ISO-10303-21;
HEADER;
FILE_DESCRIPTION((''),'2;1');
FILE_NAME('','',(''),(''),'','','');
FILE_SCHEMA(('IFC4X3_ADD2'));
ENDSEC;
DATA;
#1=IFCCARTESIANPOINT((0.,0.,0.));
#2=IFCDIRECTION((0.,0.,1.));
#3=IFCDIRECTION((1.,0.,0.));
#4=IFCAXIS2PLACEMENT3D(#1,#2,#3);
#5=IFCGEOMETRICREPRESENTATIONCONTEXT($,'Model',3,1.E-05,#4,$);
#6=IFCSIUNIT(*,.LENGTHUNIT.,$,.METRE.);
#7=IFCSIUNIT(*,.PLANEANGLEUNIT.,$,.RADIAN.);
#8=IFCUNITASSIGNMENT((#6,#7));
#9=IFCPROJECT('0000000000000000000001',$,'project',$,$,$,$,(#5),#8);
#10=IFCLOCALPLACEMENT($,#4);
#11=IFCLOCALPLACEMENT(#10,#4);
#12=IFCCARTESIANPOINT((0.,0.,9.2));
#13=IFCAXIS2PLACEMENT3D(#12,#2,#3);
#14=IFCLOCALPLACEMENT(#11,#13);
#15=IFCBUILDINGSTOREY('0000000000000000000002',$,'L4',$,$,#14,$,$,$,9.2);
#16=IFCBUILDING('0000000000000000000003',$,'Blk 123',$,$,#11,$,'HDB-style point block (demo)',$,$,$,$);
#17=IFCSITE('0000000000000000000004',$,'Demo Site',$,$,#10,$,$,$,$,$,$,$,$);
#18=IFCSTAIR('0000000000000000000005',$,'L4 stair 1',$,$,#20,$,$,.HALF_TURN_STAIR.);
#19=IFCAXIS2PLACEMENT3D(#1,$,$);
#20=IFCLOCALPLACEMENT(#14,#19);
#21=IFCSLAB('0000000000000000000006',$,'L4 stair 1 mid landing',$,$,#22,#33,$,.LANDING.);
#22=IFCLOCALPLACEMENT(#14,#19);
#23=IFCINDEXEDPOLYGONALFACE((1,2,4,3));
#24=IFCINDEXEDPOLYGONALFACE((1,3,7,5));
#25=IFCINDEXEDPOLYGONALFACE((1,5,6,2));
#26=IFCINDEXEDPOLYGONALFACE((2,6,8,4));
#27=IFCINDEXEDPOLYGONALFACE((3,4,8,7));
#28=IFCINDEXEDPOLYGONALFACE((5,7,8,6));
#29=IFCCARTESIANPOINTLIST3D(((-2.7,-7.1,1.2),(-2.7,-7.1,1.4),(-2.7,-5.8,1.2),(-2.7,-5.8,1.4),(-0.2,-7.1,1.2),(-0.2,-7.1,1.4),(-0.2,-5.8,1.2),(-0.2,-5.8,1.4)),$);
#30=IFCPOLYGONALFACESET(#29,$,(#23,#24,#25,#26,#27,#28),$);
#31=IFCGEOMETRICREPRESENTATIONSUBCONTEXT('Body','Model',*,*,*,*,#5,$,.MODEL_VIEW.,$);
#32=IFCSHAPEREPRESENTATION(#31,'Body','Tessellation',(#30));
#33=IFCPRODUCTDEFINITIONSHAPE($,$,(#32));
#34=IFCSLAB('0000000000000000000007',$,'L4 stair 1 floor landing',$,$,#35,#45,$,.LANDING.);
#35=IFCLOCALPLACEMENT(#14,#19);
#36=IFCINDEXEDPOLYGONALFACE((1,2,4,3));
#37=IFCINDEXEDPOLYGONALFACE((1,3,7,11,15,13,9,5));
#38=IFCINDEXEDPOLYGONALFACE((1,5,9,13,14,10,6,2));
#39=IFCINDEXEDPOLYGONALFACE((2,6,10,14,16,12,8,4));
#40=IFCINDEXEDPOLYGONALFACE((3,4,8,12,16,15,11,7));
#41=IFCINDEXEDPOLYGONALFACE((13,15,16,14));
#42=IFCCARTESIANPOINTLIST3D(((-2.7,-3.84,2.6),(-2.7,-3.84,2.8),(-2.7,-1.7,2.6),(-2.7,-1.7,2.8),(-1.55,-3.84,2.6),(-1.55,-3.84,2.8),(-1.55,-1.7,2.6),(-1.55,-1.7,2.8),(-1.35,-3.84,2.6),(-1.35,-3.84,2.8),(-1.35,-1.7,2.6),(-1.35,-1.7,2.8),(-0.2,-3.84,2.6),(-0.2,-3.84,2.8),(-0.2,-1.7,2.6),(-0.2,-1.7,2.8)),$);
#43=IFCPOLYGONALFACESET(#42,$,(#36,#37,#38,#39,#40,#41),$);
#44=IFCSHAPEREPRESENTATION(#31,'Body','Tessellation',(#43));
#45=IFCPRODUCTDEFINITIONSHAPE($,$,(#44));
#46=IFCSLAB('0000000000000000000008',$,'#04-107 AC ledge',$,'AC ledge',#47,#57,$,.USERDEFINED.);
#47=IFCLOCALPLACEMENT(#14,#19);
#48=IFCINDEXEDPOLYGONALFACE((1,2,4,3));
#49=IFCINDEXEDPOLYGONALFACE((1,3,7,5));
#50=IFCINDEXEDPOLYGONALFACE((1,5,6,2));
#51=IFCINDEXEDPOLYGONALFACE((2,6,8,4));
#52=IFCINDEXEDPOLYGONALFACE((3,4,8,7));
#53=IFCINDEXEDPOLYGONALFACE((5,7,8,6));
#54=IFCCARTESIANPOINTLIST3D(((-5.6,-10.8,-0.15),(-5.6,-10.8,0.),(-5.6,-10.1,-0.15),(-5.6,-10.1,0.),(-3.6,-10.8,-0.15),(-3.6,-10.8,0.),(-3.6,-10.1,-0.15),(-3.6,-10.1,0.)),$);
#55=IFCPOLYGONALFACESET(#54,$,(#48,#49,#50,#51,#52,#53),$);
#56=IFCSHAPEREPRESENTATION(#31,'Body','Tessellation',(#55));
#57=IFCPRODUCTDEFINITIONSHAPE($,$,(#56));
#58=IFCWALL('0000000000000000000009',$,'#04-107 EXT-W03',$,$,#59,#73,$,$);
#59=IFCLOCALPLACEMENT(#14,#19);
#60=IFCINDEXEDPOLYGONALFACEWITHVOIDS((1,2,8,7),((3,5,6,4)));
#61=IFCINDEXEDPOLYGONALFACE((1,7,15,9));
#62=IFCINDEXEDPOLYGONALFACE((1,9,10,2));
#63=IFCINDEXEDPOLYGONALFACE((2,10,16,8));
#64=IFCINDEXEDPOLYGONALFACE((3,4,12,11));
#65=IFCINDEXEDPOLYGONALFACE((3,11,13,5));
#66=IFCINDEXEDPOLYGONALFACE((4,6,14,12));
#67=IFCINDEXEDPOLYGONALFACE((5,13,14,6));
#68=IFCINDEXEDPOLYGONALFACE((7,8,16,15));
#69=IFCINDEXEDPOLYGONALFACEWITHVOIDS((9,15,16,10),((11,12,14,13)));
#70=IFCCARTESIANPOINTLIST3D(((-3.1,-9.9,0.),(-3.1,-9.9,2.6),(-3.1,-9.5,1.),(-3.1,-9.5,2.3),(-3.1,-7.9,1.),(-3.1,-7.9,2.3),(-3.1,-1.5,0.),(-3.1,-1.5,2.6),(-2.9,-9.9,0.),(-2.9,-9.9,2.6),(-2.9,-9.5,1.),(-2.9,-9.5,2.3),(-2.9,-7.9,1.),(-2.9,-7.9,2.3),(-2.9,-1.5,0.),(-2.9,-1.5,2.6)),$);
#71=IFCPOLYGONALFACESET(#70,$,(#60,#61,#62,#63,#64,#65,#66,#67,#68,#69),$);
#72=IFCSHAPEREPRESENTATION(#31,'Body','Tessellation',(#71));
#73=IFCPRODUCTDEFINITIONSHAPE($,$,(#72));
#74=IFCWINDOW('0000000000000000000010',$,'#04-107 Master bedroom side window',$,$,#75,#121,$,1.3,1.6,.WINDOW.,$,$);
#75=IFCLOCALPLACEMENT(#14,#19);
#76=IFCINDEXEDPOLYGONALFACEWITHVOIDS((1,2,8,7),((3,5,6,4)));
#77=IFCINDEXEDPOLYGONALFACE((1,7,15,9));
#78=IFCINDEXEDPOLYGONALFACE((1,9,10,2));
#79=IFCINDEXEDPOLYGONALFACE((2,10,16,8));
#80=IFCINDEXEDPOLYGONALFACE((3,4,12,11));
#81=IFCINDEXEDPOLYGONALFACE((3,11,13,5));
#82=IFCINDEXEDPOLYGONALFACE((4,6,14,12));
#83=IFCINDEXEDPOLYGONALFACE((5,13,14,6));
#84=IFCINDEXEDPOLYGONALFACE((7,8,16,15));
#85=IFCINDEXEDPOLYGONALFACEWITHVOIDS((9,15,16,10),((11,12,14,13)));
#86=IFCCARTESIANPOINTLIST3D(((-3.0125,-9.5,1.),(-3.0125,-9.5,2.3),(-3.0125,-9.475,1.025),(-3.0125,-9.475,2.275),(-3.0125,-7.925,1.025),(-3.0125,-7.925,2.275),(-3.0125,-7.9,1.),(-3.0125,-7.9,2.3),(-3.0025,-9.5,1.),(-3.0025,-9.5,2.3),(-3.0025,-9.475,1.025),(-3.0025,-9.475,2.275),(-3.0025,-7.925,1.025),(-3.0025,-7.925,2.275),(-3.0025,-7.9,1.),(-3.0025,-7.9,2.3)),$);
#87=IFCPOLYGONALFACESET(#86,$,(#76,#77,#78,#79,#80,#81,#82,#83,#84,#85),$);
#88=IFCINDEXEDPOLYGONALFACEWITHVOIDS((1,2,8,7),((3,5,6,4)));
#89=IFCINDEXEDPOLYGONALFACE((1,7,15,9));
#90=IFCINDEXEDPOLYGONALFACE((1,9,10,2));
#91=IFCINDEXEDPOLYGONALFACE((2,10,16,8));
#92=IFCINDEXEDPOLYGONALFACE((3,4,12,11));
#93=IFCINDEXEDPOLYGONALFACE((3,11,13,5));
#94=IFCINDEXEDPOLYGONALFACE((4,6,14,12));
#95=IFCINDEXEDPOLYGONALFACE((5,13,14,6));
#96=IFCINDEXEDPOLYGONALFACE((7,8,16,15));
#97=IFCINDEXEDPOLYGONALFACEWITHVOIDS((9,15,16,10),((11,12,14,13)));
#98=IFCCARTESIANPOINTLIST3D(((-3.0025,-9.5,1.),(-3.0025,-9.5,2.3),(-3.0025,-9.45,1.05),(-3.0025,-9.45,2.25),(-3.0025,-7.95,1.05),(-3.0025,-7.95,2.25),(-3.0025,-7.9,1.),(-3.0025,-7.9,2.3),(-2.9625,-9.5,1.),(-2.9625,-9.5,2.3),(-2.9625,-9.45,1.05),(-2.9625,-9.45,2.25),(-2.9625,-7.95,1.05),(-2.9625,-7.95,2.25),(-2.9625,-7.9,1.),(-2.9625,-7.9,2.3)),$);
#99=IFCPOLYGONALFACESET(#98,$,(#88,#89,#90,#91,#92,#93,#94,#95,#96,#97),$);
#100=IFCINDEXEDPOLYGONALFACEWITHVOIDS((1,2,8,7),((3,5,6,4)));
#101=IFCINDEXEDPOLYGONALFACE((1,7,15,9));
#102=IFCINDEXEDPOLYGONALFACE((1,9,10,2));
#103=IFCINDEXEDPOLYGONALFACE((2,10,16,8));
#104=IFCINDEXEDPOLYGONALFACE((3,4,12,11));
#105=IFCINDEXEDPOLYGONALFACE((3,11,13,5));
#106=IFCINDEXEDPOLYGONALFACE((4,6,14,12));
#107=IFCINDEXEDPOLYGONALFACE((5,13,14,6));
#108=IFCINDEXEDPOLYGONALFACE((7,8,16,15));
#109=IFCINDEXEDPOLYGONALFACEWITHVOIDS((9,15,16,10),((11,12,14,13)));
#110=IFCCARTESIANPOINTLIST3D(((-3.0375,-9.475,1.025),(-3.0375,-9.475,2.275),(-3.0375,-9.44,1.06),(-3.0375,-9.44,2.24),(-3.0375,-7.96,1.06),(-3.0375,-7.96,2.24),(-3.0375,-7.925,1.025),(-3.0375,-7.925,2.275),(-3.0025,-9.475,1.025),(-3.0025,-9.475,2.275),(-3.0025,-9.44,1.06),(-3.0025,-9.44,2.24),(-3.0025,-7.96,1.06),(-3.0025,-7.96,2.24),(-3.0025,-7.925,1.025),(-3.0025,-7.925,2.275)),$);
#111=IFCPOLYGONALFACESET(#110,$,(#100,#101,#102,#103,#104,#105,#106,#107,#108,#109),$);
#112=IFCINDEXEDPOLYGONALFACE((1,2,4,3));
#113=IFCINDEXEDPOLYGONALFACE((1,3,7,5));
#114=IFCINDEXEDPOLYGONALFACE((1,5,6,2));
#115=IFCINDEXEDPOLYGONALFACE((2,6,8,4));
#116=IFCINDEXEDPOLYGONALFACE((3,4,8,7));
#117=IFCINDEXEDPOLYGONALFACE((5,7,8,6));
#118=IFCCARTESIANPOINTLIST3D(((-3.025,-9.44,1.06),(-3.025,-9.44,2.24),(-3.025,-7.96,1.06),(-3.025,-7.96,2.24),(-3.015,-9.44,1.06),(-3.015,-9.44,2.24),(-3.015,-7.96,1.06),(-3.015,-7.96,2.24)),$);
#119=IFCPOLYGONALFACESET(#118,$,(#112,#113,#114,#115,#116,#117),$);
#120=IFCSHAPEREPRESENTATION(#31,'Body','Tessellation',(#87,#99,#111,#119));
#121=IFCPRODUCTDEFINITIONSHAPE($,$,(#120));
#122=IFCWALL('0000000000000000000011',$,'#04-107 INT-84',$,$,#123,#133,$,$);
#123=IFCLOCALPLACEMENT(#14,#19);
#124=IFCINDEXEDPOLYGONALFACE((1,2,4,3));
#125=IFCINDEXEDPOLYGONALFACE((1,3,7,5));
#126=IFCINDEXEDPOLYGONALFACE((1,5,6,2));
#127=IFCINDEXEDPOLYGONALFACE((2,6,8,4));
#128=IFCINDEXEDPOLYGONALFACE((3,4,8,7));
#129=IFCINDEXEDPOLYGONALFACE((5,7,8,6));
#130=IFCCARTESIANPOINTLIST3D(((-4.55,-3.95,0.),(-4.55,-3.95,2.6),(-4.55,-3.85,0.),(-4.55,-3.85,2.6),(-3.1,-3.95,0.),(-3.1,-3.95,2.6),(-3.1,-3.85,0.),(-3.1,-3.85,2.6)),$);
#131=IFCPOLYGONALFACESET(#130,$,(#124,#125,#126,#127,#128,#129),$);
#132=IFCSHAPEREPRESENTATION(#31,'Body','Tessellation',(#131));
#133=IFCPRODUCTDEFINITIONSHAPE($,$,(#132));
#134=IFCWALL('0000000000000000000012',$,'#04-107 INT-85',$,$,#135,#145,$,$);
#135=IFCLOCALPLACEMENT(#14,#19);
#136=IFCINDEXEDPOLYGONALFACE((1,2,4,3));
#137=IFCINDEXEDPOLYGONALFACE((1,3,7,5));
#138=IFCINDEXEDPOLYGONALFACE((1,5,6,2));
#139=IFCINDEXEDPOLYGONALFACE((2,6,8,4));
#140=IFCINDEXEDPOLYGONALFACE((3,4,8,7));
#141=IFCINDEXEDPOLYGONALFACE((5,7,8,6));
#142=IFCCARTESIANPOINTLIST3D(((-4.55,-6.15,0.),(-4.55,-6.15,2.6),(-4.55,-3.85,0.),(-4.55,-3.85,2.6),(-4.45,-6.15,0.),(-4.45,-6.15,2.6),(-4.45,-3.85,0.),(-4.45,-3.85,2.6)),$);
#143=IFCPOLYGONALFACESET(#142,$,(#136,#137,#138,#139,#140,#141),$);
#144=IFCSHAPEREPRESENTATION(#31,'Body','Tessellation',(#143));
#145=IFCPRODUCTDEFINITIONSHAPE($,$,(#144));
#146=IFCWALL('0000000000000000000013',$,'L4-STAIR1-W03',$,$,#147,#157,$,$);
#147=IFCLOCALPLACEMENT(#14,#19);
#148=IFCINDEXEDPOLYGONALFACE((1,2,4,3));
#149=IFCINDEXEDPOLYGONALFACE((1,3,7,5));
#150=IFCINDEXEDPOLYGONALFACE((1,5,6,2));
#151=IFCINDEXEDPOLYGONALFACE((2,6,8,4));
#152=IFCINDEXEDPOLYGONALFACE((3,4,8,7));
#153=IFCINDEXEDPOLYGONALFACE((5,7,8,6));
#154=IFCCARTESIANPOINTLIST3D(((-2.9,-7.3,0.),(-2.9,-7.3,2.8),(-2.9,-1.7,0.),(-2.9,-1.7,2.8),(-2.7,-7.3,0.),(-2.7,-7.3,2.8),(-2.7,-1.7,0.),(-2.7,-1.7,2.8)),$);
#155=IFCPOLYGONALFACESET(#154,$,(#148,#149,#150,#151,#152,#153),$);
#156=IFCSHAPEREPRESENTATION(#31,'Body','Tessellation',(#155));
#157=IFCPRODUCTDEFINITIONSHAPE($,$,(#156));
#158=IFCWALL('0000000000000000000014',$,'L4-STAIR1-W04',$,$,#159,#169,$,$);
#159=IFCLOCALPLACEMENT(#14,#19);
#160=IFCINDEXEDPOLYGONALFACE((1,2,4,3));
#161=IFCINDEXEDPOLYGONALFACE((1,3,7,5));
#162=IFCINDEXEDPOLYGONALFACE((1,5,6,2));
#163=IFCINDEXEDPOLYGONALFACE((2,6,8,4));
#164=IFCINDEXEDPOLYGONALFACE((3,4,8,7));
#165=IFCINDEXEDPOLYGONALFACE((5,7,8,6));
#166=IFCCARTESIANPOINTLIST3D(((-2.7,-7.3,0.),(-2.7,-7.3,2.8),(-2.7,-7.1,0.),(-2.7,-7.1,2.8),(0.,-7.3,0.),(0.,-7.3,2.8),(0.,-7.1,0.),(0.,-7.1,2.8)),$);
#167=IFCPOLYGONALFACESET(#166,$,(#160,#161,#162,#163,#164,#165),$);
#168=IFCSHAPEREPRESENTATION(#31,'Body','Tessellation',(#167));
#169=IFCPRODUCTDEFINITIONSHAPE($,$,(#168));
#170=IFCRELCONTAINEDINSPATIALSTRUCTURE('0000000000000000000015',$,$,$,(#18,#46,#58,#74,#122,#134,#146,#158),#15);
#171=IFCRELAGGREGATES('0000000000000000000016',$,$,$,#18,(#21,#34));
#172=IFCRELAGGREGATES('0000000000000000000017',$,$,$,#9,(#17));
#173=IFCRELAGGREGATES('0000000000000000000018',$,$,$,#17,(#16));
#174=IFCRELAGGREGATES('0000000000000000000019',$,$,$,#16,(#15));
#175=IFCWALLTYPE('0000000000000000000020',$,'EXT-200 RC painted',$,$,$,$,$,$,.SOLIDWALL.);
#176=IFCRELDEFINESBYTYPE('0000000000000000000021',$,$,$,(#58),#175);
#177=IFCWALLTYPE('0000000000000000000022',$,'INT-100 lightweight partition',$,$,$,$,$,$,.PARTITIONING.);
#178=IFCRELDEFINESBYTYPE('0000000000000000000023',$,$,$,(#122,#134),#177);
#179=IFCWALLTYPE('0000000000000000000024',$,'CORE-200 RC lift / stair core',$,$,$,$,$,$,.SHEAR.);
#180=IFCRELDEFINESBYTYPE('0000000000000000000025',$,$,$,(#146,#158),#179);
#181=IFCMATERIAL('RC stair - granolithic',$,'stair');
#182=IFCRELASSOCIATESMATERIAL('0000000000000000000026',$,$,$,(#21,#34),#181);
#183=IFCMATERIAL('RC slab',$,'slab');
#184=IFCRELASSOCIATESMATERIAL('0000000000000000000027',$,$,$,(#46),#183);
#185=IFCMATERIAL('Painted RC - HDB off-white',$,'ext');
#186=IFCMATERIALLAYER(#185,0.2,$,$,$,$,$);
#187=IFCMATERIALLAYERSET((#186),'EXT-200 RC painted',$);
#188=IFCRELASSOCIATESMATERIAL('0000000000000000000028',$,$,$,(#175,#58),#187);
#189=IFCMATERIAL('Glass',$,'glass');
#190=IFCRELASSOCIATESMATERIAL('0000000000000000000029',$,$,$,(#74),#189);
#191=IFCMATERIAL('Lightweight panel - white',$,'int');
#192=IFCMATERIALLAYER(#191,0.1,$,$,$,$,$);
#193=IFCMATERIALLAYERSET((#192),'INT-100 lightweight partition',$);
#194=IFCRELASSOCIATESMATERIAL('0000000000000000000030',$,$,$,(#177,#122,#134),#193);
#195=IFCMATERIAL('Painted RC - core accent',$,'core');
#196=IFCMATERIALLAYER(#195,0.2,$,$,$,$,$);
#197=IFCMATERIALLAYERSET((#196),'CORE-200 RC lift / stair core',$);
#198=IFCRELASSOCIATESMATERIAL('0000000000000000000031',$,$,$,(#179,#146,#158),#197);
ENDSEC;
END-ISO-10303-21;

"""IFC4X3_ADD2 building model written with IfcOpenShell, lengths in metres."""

from ifc_helpers import new_model, si_unit, frame, origin, origin_with_axes, place, context, subcontext, project, spatial, polyline, line, indexed_curve, outline, extrude, material, layer, layer_set, layer_usage, type_object, element, fill, aggregate, save


model = new_model("IFC4X3_ADD2")

# Units and contexts
model_context = context("Model", 3, precision=1e-05, world=origin_with_axes())
body_context = subcontext(model_context, "Body", "Model", "MODEL_VIEW")
ifc_project = project(units=[si_unit("LENGTHUNIT", "METRE"), si_unit("PLANEANGLEUNIT", "RADIAN")], contexts=[model_context])

# Site, building, storey
site_placement = place(None, origin_with_axes())
site = spatial("IfcSite", under=ifc_project, at=site_placement, Name="Demo Site")
building_placement = place(site_placement, origin_with_axes())
building = spatial("IfcBuilding", under=site, at=building_placement, Name="Blk 123", LongName="HDB-style point block (demo)")
storey_placement = place(building_placement, frame((0.0, 0.0, 9.2), z_axis=(0.0, 0.0, 1.0), x_axis=(1.0, 0.0, 0.0)))
storey = spatial("IfcBuildingStorey", under=building, at=storey_placement, Name="L4", Elevation=9.2)

# Stair, slabs
stair_placement = place(storey_placement, frame((-2.7, -7.1, 0.0), z_axis=(0.0, 0.0, 1.0), x_axis=(1.0, 0.0, 0.0)))
stair = element("IfcStair", 1, at=stair_placement, inside=storey, Name="L4 stair 1", PredefinedType="HALF_TURN_STAIR")
ifc_material_1 = material(Name="RC stair - granolithic", Category="stair")
slab_1_placement = place(stair_placement, frame((1.25, 0.65, 1.2), z_axis=(0.0, 0.0, 1.0), x_axis=(1.0, 0.0, 0.0)))
slab_1 = element("IfcSlab", 2, at=slab_1_placement, material=ifc_material_1, Name="L4 stair 1 mid landing", PredefinedType="LANDING", context=body_context, shape_type="SweptSolid", body=[
    extrude(outline(polyline([(1.25, -0.65), (1.25, 0.65), (-1.25, 0.65), (-1.25, -0.65), (1.25, -0.65)])), origin(), (0.0, 0.0, 1.0), 0.2),
])
slab_2_placement = place(stair_placement, frame((1.25, 4.33, 2.6), z_axis=(0.0, 0.0, 1.0), x_axis=(1.0, 0.0, 0.0)))
slab_2 = element("IfcSlab", 3, at=slab_2_placement, material=ifc_material_1, Name="L4 stair 1 floor landing", PredefinedType="LANDING", context=body_context, shape_type="SweptSolid", body=[
    extrude(outline(polyline([(-0.1, 1.07), (-1.25, 1.07), (-1.25, -1.07), (-0.1, -1.07), (0.1, -1.07), (1.25, -1.07), (1.25, 1.07), (0.1, 1.07), (-0.1, 1.07)])), origin(), (0.0, 0.0, 1.0), 0.2),
])

# Slab
ifc_material_2 = material(Name="RC slab", Category="slab")
slab_3_placement = place(storey_placement, frame((-4.6, -10.45, -0.15), z_axis=(0.0, 0.0, 1.0), x_axis=(1.0, 0.0, 0.0)))
element("IfcSlab", 4, at=slab_3_placement, inside=storey, material=ifc_material_2, Name="#04-107 AC ledge", ObjectType="AC ledge", PredefinedType="USERDEFINED", context=body_context, shape_type="SweptSolid", body=[
    extrude(outline(polyline([(-1.0, 0.35), (-1.0, -0.35), (1.0, -0.35), (1.0, 0.35), (-1.0, 0.35)])), origin(), (0.0, 0.0, 1.0), 0.15),
])

# Wall, opening, window
ifc_material_3 = material(Name="Painted RC - HDB off-white", Category="ext")
ifc_layer_1 = layer(ifc_material_3, 0.2)
ifc_layer_set_1 = layer_set([ifc_layer_1], Name="EXT-200 RC painted")
ifc_layer_usage_1 = layer_usage(ifc_layer_set_1, "AXIS2", "POSITIVE", 0.0)
wall_type_1 = type_object("IfcWallType", Name="EXT-200 RC painted", PredefinedType="SOLIDWALL", material=ifc_layer_set_1)
wall_1_placement = place(storey_placement, frame((-2.9, -9.9, 0.0), z_axis=(0.0, 0.0, 1.0), x_axis=(0.0, 1.0, 0.0)))
wall_1 = element("IfcWall", 5, at=wall_1_placement, inside=storey, type_object=wall_type_1, material=ifc_layer_usage_1, Name="#04-107 EXT-W03", context=body_context, shape_type="SweptSolid", body=[
    extrude(outline(indexed_curve([(0.0, 0.0), (0.0, 0.2), (8.4, 0.2), (8.4, 0.0), (0.0, 0.0)], self_intersect=False)), origin_with_axes(), (0.0, 0.0, 1.0), 2.6),
])
opening_1_placement = place(wall_1_placement, frame((0.4, -0.1, 1.0), z_axis=(0.0, 0.0, 1.0), x_axis=(1.0, 0.0, 0.0)))
opening_1 = element("IfcOpeningElement", 6, at=opening_1_placement, cuts=wall_1, context=body_context, shape_type="SweptSolid", body=[
    extrude(outline(indexed_curve([(0.0, 0.0), (0.0, 0.4), (1.6, 0.4), (1.6, 0.0), (0.0, 0.0)], self_intersect=False)), origin_with_axes(), (0.0, 0.0, 1.0), 1.3),
])
ifc_material_4 = material(Name="Glass", Category="glass")
window_placement = place(opening_1_placement, frame((0.0, 0.1125, 0.0), z_axis=(0.0, 0.0, 1.0), x_axis=(1.0, 0.0, 0.0)))
window = element("IfcWindow", 7, at=window_placement, inside=storey, material=ifc_material_4, Name="#04-107 Master bedroom side window", OverallHeight=1.3, OverallWidth=1.6, PredefinedType="WINDOW", context=body_context, shape_type="SweptSolid", body=[
    extrude(outline(indexed_curve([(0.0, 0.0), (1.6, 0.0), (1.6, 1.3), (0.0, 1.3)], segments=[line(1, 2, 3, 4, 1)]), holes=[indexed_curve([(0.025, 0.025), (1.575, 0.025), (1.575, 1.275), (0.025, 1.275)], segments=[line(1, 2, 3, 4, 1)])]), frame((0.0, 0.09, 0.0), z_axis=(0.0, -1.0, 0.0), x_axis=(1.0, 0.0, 0.0)), (0.0, 0.0, -1.0), 0.01),
    extrude(outline(indexed_curve([(0.0, 0.0), (1.6, 0.0), (1.6, 1.3), (0.0, 1.3)], segments=[line(1, 2, 3, 4, 1)]), holes=[indexed_curve([(0.05, 0.05), (1.55, 0.05), (1.55, 1.25), (0.05, 1.25)], segments=[line(1, 2, 3, 4, 1)])]), frame((0.0, 0.05, 0.0), z_axis=(0.0, -1.0, 0.0), x_axis=(1.0, 0.0, 0.0)), (0.0, 0.0, -1.0), 0.04),
    extrude(outline(indexed_curve([(0.0, 0.0), (1.55, 0.0), (1.55, 1.25), (0.0, 1.25)], segments=[line(1, 2, 3, 4, 1)]), holes=[indexed_curve([(0.035, 0.035), (1.515, 0.035), (1.515, 1.215), (0.035, 1.215)], segments=[line(1, 2, 3, 4, 1)])]), frame((0.025, 0.09, 0.025), z_axis=(0.0, -1.0, 0.0), x_axis=(1.0, 0.0, 0.0)), (0.0, 0.0, -1.0), 0.035),
    extrude(outline(indexed_curve([(0.035, 0.035), (1.515, 0.035), (1.515, 1.215), (0.035, 1.215)], segments=[line(1, 2, 3, 4, 1)])), frame((0.025, 0.1025, 0.025), z_axis=(0.0, -1.0, 0.0), x_axis=(1.0, 0.0, 0.0)), (0.0, 0.0, -1.0), 0.01),
])
fill(opening_1, window)

# Shared definitions
ifc_material_5 = material(Name="Lightweight panel - white", Category="int")
ifc_layer_2 = layer(ifc_material_5, 0.1)
ifc_layer_set_2 = layer_set([ifc_layer_2], Name="INT-100 lightweight partition")
ifc_layer_usage_2 = layer_usage(ifc_layer_set_2, "AXIS2", "POSITIVE", -0.05)
wall_type_2 = type_object("IfcWallType", Name="INT-100 lightweight partition", PredefinedType="PARTITIONING", material=ifc_layer_set_2)

# Walls
wall_2_placement = place(storey_placement, frame((-3.1, -3.9, 0.0), z_axis=(0.0, 0.0, 1.0), x_axis=(-1.0, 0.0, 0.0)))
element("IfcWall", 8, at=wall_2_placement, inside=storey, type_object=wall_type_2, material=ifc_layer_usage_2, Name="#04-107 INT-84", context=body_context, shape_type="SweptSolid", body=[
    extrude(outline(indexed_curve([(0.0, 0.0), (0.0, 0.1), (1.45, 0.1), (1.45, 0.0), (0.0, 0.0)], self_intersect=False)), frame((0.0, -0.05, 0.0), z_axis=(0.0, 0.0, 1.0), x_axis=(1.0, 0.0, 0.0)), (0.0, 0.0, 1.0), 2.6),
])
wall_3_placement = place(storey_placement, frame((-4.5, -3.85, 0.0), z_axis=(0.0, 0.0, 1.0), x_axis=(0.0, -1.0, 0.0)))
element("IfcWall", 9, at=wall_3_placement, inside=storey, type_object=wall_type_2, material=ifc_layer_usage_2, Name="#04-107 INT-85", context=body_context, shape_type="SweptSolid", body=[
    extrude(outline(indexed_curve([(0.0, 0.0), (0.0, 0.1), (2.3, 0.1), (2.3, 0.0), (0.0, 0.0)], self_intersect=False)), frame((0.0, -0.05, 0.0), z_axis=(0.0, 0.0, 1.0), x_axis=(1.0, 0.0, 0.0)), (0.0, 0.0, 1.0), 2.6),
])

# Walls
ifc_material_6 = material(Name="Painted RC - core accent", Category="core")
ifc_layer_3 = layer(ifc_material_6, 0.2)
ifc_layer_set_3 = layer_set([ifc_layer_3], Name="CORE-200 RC lift / stair core")
ifc_layer_usage_3 = layer_usage(ifc_layer_set_3, "AXIS2", "POSITIVE", 0.0)
wall_type_3 = type_object("IfcWallType", Name="CORE-200 RC lift / stair core", PredefinedType="SHEAR", material=ifc_layer_set_3)
wall_4_placement = place(storey_placement, frame((-2.9, -1.7, 0.0), z_axis=(0.0, 0.0, 1.0), x_axis=(0.0, -1.0, 0.0)))
element("IfcWall", 10, at=wall_4_placement, inside=storey, type_object=wall_type_3, material=ifc_layer_usage_3, Name="L4-STAIR1-W03", context=body_context, shape_type="SweptSolid", body=[
    extrude(outline(indexed_curve([(0.0, 0.0), (0.0, 0.2), (5.6, 0.2), (5.6, 0.0), (0.0, 0.0)], self_intersect=False)), origin_with_axes(), (0.0, 0.0, 1.0), 2.8),
])
wall_5_placement = place(storey_placement, frame((-2.7, -7.3, 0.0), z_axis=(0.0, 0.0, 1.0), x_axis=(1.0, 0.0, 0.0)))
element("IfcWall", 11, at=wall_5_placement, inside=storey, type_object=wall_type_3, material=ifc_layer_usage_3, Name="L4-STAIR1-W04", context=body_context, shape_type="SweptSolid", body=[
    extrude(outline(indexed_curve([(0.0, 0.0), (0.0, 0.2), (2.7, 0.2), (2.7, 0.0), (0.0, 0.0)], self_intersect=False)), origin_with_axes(), (0.0, 0.0, 1.0), 2.8),
])

aggregate(stair, [slab_1, slab_2])

save(model, "model.ifc")
